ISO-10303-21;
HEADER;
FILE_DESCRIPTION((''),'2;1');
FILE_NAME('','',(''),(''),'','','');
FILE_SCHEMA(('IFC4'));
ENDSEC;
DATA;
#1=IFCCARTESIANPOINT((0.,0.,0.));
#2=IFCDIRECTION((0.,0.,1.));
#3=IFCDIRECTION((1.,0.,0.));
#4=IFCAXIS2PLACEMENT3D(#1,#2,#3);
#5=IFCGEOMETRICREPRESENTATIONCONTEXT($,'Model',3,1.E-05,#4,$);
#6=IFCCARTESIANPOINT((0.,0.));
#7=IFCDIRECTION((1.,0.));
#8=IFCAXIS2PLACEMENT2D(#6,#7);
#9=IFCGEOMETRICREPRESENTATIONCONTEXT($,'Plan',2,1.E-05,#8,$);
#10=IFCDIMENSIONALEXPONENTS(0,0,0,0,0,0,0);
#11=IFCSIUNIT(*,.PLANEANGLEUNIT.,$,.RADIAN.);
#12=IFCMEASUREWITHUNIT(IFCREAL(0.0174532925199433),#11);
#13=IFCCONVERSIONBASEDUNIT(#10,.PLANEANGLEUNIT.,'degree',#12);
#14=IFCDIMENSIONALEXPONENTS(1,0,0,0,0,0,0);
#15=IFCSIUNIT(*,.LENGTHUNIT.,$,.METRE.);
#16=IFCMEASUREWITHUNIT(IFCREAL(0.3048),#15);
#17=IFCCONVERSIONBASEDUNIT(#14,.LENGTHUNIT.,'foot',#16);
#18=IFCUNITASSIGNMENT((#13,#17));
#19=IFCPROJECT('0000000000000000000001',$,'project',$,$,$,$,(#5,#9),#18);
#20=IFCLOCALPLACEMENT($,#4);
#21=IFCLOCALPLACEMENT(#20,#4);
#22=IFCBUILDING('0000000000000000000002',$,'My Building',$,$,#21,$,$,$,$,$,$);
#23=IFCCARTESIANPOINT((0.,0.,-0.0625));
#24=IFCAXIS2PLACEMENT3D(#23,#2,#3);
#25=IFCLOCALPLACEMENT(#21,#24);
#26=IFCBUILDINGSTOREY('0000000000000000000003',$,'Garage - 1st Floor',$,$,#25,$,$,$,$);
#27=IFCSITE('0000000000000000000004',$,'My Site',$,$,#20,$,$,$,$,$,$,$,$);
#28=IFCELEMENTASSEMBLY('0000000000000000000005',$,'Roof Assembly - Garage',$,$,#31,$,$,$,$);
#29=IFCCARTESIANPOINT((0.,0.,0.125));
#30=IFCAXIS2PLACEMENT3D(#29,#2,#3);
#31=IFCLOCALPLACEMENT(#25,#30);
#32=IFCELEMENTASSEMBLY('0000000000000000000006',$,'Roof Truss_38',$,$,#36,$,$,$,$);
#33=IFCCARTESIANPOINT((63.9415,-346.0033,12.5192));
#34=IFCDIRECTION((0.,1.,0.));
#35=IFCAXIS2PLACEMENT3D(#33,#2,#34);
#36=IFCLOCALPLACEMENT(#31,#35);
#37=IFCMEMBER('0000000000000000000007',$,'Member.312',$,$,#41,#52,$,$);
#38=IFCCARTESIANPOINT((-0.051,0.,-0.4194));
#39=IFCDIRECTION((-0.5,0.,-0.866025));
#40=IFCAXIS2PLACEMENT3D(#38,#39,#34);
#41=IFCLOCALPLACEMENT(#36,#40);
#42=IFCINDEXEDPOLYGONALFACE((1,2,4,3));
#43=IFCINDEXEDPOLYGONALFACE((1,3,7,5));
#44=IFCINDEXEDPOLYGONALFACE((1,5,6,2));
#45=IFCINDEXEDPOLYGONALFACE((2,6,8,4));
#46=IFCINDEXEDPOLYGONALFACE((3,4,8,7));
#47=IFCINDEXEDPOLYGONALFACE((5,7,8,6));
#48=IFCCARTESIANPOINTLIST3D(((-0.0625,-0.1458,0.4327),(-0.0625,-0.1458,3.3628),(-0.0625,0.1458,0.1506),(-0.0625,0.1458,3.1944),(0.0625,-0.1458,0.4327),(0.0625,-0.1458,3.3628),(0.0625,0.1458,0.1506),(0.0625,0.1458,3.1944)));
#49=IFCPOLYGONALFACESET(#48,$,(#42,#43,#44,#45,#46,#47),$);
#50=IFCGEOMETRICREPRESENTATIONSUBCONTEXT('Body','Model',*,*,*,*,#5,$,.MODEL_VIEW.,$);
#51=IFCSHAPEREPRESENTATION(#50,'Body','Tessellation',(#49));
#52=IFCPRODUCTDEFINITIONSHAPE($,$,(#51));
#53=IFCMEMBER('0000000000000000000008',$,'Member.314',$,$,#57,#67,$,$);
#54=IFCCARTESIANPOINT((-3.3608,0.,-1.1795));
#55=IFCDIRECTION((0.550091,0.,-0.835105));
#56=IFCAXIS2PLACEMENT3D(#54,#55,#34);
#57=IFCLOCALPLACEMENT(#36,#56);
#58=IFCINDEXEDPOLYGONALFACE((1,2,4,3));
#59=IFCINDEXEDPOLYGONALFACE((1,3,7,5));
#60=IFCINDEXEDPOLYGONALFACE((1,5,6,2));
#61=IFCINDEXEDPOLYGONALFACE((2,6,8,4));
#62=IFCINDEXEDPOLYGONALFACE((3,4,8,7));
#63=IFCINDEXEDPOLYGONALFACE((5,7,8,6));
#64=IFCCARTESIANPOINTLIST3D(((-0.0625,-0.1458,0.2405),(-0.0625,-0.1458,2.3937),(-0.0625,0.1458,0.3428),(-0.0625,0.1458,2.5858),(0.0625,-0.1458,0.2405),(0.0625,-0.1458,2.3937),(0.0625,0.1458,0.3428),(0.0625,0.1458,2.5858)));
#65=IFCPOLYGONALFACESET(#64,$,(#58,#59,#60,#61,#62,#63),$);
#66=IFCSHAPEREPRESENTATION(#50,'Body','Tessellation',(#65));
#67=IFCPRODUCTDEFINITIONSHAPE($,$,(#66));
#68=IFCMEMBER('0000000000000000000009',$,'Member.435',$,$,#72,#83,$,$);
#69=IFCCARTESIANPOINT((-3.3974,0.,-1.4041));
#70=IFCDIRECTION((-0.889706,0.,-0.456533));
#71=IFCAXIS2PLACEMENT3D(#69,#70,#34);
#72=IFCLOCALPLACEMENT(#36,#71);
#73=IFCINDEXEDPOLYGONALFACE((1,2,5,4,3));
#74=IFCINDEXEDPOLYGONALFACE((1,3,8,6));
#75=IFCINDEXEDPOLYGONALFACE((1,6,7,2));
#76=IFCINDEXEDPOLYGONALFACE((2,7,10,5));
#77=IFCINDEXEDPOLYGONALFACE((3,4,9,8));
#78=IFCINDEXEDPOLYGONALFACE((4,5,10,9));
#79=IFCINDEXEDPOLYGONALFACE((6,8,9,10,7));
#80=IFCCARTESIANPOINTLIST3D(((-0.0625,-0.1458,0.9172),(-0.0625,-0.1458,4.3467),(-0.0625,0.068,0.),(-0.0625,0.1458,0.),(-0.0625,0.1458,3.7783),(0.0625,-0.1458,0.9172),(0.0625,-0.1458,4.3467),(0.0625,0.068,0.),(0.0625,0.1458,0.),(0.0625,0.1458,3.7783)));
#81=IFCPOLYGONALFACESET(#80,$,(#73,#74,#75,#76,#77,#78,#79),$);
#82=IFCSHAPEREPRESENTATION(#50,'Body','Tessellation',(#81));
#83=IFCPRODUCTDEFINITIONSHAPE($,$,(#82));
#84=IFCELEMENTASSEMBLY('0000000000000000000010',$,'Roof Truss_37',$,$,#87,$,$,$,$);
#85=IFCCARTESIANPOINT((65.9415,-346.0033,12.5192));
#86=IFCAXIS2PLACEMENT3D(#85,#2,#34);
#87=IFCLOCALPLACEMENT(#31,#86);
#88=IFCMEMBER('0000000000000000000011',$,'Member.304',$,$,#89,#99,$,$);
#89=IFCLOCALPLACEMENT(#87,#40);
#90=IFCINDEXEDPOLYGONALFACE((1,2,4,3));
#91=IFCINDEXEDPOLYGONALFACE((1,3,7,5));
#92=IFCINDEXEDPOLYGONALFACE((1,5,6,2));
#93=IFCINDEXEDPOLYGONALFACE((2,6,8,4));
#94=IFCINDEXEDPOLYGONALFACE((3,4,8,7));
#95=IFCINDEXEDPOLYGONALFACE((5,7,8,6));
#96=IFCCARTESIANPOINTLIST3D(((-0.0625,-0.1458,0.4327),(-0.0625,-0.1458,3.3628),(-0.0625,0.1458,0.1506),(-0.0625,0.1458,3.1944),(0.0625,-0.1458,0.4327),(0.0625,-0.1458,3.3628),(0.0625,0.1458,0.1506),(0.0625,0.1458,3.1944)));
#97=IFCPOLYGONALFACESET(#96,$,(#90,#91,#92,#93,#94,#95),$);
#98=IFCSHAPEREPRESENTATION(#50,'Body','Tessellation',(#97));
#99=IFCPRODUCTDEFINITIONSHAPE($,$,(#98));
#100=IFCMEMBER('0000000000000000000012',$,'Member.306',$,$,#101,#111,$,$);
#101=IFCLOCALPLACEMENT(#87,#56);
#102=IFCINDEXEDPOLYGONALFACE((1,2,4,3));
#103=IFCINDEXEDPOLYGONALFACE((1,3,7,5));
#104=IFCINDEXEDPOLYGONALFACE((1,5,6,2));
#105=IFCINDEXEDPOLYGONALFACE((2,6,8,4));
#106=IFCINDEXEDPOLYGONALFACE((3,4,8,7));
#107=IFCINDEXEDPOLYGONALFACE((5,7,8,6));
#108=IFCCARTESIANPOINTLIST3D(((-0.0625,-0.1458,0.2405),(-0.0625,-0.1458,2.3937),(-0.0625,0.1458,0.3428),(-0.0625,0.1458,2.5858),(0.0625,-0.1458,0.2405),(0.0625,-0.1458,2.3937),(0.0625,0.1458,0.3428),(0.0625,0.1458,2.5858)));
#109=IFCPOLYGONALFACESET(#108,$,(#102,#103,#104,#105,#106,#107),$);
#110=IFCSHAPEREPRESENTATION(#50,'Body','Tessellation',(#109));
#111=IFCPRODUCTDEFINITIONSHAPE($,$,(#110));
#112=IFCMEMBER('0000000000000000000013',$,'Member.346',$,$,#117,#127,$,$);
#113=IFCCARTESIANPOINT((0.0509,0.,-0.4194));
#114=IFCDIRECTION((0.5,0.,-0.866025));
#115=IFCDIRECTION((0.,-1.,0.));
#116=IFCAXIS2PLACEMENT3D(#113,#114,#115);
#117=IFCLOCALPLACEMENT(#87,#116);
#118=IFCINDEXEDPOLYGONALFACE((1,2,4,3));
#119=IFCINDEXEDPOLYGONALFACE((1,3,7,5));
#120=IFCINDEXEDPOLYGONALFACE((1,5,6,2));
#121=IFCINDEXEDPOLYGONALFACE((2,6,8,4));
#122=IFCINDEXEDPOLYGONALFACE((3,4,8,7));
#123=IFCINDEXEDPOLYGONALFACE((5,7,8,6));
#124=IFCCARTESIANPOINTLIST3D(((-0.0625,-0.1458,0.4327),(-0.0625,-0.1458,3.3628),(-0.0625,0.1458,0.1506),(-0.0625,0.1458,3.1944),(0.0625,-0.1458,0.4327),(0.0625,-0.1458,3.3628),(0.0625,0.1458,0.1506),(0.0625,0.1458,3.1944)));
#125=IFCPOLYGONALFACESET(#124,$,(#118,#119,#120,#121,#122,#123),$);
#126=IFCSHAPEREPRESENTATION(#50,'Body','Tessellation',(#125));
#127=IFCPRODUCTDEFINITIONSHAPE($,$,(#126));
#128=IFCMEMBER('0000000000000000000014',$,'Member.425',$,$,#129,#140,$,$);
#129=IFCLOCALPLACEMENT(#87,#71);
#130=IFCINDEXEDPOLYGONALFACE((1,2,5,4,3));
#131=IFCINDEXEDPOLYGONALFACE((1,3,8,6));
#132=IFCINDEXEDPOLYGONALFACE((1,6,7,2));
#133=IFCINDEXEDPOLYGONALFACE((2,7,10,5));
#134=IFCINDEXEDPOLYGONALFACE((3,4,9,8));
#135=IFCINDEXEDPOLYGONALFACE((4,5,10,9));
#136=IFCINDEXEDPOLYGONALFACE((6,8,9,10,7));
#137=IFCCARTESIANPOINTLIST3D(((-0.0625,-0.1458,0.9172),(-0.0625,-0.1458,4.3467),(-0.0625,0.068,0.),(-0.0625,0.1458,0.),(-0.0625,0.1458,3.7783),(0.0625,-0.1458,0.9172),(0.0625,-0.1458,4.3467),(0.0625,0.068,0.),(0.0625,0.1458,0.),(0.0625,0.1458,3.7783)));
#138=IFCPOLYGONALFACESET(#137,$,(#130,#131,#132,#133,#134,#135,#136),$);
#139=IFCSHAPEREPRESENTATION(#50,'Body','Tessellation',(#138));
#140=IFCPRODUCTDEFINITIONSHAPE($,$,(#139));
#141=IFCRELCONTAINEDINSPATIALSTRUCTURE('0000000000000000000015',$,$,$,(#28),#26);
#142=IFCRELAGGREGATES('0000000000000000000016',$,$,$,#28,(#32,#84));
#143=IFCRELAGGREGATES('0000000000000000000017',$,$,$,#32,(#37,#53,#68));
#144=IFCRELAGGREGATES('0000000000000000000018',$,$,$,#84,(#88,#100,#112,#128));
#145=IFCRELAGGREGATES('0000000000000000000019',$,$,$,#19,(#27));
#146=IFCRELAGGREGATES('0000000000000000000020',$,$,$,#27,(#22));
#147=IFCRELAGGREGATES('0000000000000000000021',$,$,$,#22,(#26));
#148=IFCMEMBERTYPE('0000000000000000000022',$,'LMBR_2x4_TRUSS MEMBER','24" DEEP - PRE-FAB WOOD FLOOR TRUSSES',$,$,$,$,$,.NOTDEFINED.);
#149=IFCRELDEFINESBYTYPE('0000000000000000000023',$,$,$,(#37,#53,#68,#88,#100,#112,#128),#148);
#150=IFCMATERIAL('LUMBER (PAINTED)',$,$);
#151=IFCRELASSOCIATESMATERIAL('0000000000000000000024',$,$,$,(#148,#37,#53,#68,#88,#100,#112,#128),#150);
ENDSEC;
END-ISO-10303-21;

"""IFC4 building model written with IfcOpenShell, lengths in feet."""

from ifc_helpers import new_model, entity, si_unit, converted_unit, frame, origin_with_axes, origin_2d_with_axis, place, context, subcontext, project, spatial, indexed_curve, outline, extrude, clip, halfspace, material, material_profile, profile_set, profile_usage, type_object, element, aggregate, save


model = new_model("IFC4")

# Units and contexts
model_context = context("Model", 3, precision=1e-05, world=origin_with_axes())
plan_context = context("Plan", 2, precision=1e-05, world=origin_2d_with_axis())
body_context = subcontext(model_context, "Body", "Model", "MODEL_VIEW")
ifc_project = project(units=[converted_unit("PLANEANGLEUNIT", "degree", entity("IfcReal", 0.0174532925199433), si_unit("PLANEANGLEUNIT", "RADIAN"), dimensions=[0, 0, 0, 0, 0, 0, 0]), converted_unit("LENGTHUNIT", "foot", entity("IfcReal", 0.3048), si_unit("LENGTHUNIT", "METRE"), dimensions=[1, 0, 0, 0, 0, 0, 0])], contexts=[model_context, plan_context])

# Site, building, storey
site_placement = place(None, origin_with_axes())
site = spatial("IfcSite", under=ifc_project, at=site_placement, Name="My Site")
building_placement = place(site_placement, origin_with_axes())
building = spatial("IfcBuilding", under=site, at=building_placement, Name="My Building")
storey_placement = place(building_placement, frame((0.0, 0.0, -0.0625), z_axis=(0.0, 0.0, 1.0), x_axis=(1.0, 0.0, 0.0)))
storey = spatial("IfcBuildingStorey", under=building, at=storey_placement, Name="Garage - 1st Floor")

# Element assemblies, members
assembly_1_placement = place(storey_placement, frame((0.0, 0.0, 0.125), z_axis=(0.0, 0.0, 1.0), x_axis=(1.0, 0.0, 0.0)))
assembly_1 = element("IfcElementAssembly", 1, at=assembly_1_placement, inside=storey, Name="Roof Assembly - Garage")
ifc_material = material(Name="LUMBER (PAINTED)")
ifc_material_profile_1 = material_profile(ifc_material, outline(indexed_curve([(-0.0625, -0.1458), (0.0625, -0.1458), (0.0625, 0.1458), (-0.0625, 0.1458), (-0.0625, -0.1458)])))
ifc_profile_set_1 = profile_set([ifc_material_profile_1])
member_type_1 = type_object("IfcMemberType", Name="LMBR_2x4_TRUSS MEMBER", Description="24\" DEEP - PRE-FAB WOOD FLOOR TRUSSES", PredefinedType="NOTDEFINED", material=ifc_profile_set_1)
assembly_2_placement = place(assembly_1_placement, frame((63.9415, -346.0033, 12.5192), z_axis=(0.0, 0.0, 1.0), x_axis=(0.0, 1.0, 0.0)))
assembly_2 = element("IfcElementAssembly", 2, at=assembly_2_placement, Name="Roof Truss_38")
ifc_profile_usage_1 = profile_usage(ifc_profile_set_1)
member_1_placement = place(assembly_2_placement, frame((-0.051, 0.0, -0.4194), z_axis=(-0.5, 0.0, -0.866025), x_axis=(0.0, 1.0, 0.0)))
member_1 = element("IfcMember", 3, at=member_1_placement, type_object=member_type_1, material=ifc_profile_usage_1, Name="Member.312", context=body_context, shape_type="Clipping", body=[
    clip(clip(extrude(outline(indexed_curve([(-0.0625, -0.1458), (0.0625, -0.1458), (0.0625, 0.1458), (-0.0625, 0.1458), (-0.0625, -0.1458)])), origin_with_axes(), (0.0, 0.0, 1.0), 3.5703), halfspace(frame((0.0, 0.2544, 0.0456), z_axis=(0.0, -0.69516, -0.718855), x_axis=(-1.0, 0.000001, 0.0)), False)), halfspace(frame((0.0, 7.9951, -1.3373), z_axis=(0.0, 0.5, 0.866026), x_axis=(1.0, 0.0, 0.0)), False)),
])
ifc_profile_usage_2 = profile_usage(ifc_profile_set_1)
member_2_placement = place(assembly_2_placement, frame((-3.3608, 0.0, -1.1795), z_axis=(0.550091, 0.0, -0.835105), x_axis=(0.0, 1.0, 0.0)))
member_2 = element("IfcMember", 4, at=member_2_placement, type_object=member_type_1, material=ifc_profile_usage_2, Name="Member.314", context=body_context, shape_type="Clipping", body=[
    clip(clip(extrude(outline(indexed_curve([(-0.0625, -0.1458), (0.0625, -0.1458), (0.0625, 0.1458), (-0.0625, 0.1458), (-0.0625, -0.1458)])), origin_with_axes(), (0.0, 0.0, 1.0), 2.7815), halfspace(frame((0.0, 3.2555, 1.4338), z_axis=(0.0, 0.331063, -0.943609), x_axis=(1.0, 0.0, 0.0)), False)), halfspace(frame((0.0, 7.9609, 7.7337), z_axis=(0.0, -0.550091, 0.835105), x_axis=(-1.0, 0.0, 0.0)), False)),
])
ifc_profile_usage_3 = profile_usage(ifc_profile_set_1)
member_3_placement = place(assembly_2_placement, frame((-3.3974, 0.0, -1.4041), z_axis=(-0.889706, 0.0, -0.456533), x_axis=(0.0, 1.0, 0.0)))
member_3 = element("IfcMember", 5, at=member_3_placement, type_object=member_type_1, material=ifc_profile_usage_3, Name="Member.435", context=body_context, shape_type="Clipping", body=[
    clip(clip(extrude(outline(indexed_curve([(-0.0625, -0.1458), (0.0625, -0.1458), (0.0625, 0.1458), (-0.0625, 0.1458), (-0.0625, -0.1458)])), origin_with_axes(), (0.0, 0.0, 1.0), 4.3542), halfspace(frame((0.0, 6.6441, -8.8858), z_axis=(0.0, 0.889707, 0.456533), x_axis=(1.0, 0.0, 0.0)), False)), halfspace(frame((0.0, 0.8902, -3.5265), z_axis=(-0.000001, -0.973882, -0.227053), x_axis=(-1.0, 0.000001, 0.0)), False)),
])
assembly_3_placement = place(assembly_1_placement, frame((65.9415, -346.0033, 12.5192), z_axis=(0.0, 0.0, 1.0), x_axis=(0.0, 1.0, 0.0)))
assembly_3 = element("IfcElementAssembly", 6, at=assembly_3_placement, Name="Roof Truss_37")
aggregate(assembly_1, [assembly_2, assembly_3])
ifc_profile_usage_4 = profile_usage(ifc_profile_set_1)
member_4_placement = place(assembly_3_placement, frame((-0.051, 0.0, -0.4194), z_axis=(-0.5, 0.0, -0.866025), x_axis=(0.0, 1.0, 0.0)))
member_4 = element("IfcMember", 7, at=member_4_placement, type_object=member_type_1, material=ifc_profile_usage_4, Name="Member.304", context=body_context, shape_type="Clipping", body=[
    clip(clip(extrude(outline(indexed_curve([(-0.0625, -0.1458), (0.0625, -0.1458), (0.0625, 0.1458), (-0.0625, 0.1458), (-0.0625, -0.1458)])), origin_with_axes(), (0.0, 0.0, 1.0), 3.5703), halfspace(frame((0.0, 0.2544, 0.0456), z_axis=(0.0, -0.69516, -0.718855), x_axis=(-1.0, 0.000001, 0.0)), False)), halfspace(frame((0.0, 7.9951, -1.3373), z_axis=(0.0, 0.5, 0.866026), x_axis=(1.0, 0.0, 0.0)), False)),
])
ifc_profile_usage_5 = profile_usage(ifc_profile_set_1)
member_5_placement = place(assembly_3_placement, frame((-3.3608, 0.0, -1.1795), z_axis=(0.550091, 0.0, -0.835105), x_axis=(0.0, 1.0, 0.0)))
member_5 = element("IfcMember", 8, at=member_5_placement, type_object=member_type_1, material=ifc_profile_usage_5, Name="Member.306", context=body_context, shape_type="Clipping", body=[
    clip(clip(extrude(outline(indexed_curve([(-0.0625, -0.1458), (0.0625, -0.1458), (0.0625, 0.1458), (-0.0625, 0.1458), (-0.0625, -0.1458)])), origin_with_axes(), (0.0, 0.0, 1.0), 2.7815), halfspace(frame((0.0, 3.2555, 1.4338), z_axis=(0.0, 0.331063, -0.943609), x_axis=(1.0, 0.0, 0.0)), False)), halfspace(frame((0.0, 7.9609, 7.7337), z_axis=(0.0, -0.550091, 0.835105), x_axis=(-1.0, 0.0, 0.0)), False)),
])
ifc_profile_usage_6 = profile_usage(ifc_profile_set_1)
member_6_placement = place(assembly_3_placement, frame((0.0509, 0.0, -0.4194), z_axis=(0.5, 0.0, -0.866025), x_axis=(0.0, -1.0, 0.0)))
member_6 = element("IfcMember", 9, at=member_6_placement, type_object=member_type_1, material=ifc_profile_usage_6, Name="Member.346", context=body_context, shape_type="Clipping", body=[
    clip(clip(extrude(outline(indexed_curve([(-0.0625, -0.1458), (0.0625, -0.1458), (0.0625, 0.1458), (-0.0625, 0.1458), (-0.0625, -0.1458)])), origin_with_axes(), (0.0, 0.0, 1.0), 3.5703), halfspace(frame((0.0, -5.0674, 6.2043), z_axis=(0.0, 0.5, 0.866025), x_axis=(1.0, 0.0, 0.0)), False)), halfspace(frame((0.0, 0.2544, 0.0456), z_axis=(0.0, -0.695161, -0.718855), x_axis=(-1.0, 0.0, 0.0)), False)),
])
ifc_profile_usage_7 = profile_usage(ifc_profile_set_1)
member_7_placement = place(assembly_3_placement, frame((-3.3974, 0.0, -1.4041), z_axis=(-0.889706, 0.0, -0.456533), x_axis=(0.0, 1.0, 0.0)))
member_7 = element("IfcMember", 10, at=member_7_placement, type_object=member_type_1, material=ifc_profile_usage_7, Name="Member.425", context=body_context, shape_type="Clipping", body=[
    clip(clip(extrude(outline(indexed_curve([(-0.0625, -0.1458), (0.0625, -0.1458), (0.0625, 0.1458), (-0.0625, 0.1458), (-0.0625, -0.1458)])), origin_with_axes(), (0.0, 0.0, 1.0), 4.3542), halfspace(frame((0.0, 6.6441, -8.8858), z_axis=(0.0, 0.889707, 0.456533), x_axis=(1.0, 0.0, 0.0)), False)), halfspace(frame((0.0, 0.8902, -3.5265), z_axis=(-0.000001, -0.973882, -0.227053), x_axis=(-1.0, 0.000001, 0.0)), False)),
])
aggregate(assembly_2, [member_1, member_2, member_3])
aggregate(assembly_3, [member_4, member_5, member_6, member_7])

save(model, "model.ifc")
